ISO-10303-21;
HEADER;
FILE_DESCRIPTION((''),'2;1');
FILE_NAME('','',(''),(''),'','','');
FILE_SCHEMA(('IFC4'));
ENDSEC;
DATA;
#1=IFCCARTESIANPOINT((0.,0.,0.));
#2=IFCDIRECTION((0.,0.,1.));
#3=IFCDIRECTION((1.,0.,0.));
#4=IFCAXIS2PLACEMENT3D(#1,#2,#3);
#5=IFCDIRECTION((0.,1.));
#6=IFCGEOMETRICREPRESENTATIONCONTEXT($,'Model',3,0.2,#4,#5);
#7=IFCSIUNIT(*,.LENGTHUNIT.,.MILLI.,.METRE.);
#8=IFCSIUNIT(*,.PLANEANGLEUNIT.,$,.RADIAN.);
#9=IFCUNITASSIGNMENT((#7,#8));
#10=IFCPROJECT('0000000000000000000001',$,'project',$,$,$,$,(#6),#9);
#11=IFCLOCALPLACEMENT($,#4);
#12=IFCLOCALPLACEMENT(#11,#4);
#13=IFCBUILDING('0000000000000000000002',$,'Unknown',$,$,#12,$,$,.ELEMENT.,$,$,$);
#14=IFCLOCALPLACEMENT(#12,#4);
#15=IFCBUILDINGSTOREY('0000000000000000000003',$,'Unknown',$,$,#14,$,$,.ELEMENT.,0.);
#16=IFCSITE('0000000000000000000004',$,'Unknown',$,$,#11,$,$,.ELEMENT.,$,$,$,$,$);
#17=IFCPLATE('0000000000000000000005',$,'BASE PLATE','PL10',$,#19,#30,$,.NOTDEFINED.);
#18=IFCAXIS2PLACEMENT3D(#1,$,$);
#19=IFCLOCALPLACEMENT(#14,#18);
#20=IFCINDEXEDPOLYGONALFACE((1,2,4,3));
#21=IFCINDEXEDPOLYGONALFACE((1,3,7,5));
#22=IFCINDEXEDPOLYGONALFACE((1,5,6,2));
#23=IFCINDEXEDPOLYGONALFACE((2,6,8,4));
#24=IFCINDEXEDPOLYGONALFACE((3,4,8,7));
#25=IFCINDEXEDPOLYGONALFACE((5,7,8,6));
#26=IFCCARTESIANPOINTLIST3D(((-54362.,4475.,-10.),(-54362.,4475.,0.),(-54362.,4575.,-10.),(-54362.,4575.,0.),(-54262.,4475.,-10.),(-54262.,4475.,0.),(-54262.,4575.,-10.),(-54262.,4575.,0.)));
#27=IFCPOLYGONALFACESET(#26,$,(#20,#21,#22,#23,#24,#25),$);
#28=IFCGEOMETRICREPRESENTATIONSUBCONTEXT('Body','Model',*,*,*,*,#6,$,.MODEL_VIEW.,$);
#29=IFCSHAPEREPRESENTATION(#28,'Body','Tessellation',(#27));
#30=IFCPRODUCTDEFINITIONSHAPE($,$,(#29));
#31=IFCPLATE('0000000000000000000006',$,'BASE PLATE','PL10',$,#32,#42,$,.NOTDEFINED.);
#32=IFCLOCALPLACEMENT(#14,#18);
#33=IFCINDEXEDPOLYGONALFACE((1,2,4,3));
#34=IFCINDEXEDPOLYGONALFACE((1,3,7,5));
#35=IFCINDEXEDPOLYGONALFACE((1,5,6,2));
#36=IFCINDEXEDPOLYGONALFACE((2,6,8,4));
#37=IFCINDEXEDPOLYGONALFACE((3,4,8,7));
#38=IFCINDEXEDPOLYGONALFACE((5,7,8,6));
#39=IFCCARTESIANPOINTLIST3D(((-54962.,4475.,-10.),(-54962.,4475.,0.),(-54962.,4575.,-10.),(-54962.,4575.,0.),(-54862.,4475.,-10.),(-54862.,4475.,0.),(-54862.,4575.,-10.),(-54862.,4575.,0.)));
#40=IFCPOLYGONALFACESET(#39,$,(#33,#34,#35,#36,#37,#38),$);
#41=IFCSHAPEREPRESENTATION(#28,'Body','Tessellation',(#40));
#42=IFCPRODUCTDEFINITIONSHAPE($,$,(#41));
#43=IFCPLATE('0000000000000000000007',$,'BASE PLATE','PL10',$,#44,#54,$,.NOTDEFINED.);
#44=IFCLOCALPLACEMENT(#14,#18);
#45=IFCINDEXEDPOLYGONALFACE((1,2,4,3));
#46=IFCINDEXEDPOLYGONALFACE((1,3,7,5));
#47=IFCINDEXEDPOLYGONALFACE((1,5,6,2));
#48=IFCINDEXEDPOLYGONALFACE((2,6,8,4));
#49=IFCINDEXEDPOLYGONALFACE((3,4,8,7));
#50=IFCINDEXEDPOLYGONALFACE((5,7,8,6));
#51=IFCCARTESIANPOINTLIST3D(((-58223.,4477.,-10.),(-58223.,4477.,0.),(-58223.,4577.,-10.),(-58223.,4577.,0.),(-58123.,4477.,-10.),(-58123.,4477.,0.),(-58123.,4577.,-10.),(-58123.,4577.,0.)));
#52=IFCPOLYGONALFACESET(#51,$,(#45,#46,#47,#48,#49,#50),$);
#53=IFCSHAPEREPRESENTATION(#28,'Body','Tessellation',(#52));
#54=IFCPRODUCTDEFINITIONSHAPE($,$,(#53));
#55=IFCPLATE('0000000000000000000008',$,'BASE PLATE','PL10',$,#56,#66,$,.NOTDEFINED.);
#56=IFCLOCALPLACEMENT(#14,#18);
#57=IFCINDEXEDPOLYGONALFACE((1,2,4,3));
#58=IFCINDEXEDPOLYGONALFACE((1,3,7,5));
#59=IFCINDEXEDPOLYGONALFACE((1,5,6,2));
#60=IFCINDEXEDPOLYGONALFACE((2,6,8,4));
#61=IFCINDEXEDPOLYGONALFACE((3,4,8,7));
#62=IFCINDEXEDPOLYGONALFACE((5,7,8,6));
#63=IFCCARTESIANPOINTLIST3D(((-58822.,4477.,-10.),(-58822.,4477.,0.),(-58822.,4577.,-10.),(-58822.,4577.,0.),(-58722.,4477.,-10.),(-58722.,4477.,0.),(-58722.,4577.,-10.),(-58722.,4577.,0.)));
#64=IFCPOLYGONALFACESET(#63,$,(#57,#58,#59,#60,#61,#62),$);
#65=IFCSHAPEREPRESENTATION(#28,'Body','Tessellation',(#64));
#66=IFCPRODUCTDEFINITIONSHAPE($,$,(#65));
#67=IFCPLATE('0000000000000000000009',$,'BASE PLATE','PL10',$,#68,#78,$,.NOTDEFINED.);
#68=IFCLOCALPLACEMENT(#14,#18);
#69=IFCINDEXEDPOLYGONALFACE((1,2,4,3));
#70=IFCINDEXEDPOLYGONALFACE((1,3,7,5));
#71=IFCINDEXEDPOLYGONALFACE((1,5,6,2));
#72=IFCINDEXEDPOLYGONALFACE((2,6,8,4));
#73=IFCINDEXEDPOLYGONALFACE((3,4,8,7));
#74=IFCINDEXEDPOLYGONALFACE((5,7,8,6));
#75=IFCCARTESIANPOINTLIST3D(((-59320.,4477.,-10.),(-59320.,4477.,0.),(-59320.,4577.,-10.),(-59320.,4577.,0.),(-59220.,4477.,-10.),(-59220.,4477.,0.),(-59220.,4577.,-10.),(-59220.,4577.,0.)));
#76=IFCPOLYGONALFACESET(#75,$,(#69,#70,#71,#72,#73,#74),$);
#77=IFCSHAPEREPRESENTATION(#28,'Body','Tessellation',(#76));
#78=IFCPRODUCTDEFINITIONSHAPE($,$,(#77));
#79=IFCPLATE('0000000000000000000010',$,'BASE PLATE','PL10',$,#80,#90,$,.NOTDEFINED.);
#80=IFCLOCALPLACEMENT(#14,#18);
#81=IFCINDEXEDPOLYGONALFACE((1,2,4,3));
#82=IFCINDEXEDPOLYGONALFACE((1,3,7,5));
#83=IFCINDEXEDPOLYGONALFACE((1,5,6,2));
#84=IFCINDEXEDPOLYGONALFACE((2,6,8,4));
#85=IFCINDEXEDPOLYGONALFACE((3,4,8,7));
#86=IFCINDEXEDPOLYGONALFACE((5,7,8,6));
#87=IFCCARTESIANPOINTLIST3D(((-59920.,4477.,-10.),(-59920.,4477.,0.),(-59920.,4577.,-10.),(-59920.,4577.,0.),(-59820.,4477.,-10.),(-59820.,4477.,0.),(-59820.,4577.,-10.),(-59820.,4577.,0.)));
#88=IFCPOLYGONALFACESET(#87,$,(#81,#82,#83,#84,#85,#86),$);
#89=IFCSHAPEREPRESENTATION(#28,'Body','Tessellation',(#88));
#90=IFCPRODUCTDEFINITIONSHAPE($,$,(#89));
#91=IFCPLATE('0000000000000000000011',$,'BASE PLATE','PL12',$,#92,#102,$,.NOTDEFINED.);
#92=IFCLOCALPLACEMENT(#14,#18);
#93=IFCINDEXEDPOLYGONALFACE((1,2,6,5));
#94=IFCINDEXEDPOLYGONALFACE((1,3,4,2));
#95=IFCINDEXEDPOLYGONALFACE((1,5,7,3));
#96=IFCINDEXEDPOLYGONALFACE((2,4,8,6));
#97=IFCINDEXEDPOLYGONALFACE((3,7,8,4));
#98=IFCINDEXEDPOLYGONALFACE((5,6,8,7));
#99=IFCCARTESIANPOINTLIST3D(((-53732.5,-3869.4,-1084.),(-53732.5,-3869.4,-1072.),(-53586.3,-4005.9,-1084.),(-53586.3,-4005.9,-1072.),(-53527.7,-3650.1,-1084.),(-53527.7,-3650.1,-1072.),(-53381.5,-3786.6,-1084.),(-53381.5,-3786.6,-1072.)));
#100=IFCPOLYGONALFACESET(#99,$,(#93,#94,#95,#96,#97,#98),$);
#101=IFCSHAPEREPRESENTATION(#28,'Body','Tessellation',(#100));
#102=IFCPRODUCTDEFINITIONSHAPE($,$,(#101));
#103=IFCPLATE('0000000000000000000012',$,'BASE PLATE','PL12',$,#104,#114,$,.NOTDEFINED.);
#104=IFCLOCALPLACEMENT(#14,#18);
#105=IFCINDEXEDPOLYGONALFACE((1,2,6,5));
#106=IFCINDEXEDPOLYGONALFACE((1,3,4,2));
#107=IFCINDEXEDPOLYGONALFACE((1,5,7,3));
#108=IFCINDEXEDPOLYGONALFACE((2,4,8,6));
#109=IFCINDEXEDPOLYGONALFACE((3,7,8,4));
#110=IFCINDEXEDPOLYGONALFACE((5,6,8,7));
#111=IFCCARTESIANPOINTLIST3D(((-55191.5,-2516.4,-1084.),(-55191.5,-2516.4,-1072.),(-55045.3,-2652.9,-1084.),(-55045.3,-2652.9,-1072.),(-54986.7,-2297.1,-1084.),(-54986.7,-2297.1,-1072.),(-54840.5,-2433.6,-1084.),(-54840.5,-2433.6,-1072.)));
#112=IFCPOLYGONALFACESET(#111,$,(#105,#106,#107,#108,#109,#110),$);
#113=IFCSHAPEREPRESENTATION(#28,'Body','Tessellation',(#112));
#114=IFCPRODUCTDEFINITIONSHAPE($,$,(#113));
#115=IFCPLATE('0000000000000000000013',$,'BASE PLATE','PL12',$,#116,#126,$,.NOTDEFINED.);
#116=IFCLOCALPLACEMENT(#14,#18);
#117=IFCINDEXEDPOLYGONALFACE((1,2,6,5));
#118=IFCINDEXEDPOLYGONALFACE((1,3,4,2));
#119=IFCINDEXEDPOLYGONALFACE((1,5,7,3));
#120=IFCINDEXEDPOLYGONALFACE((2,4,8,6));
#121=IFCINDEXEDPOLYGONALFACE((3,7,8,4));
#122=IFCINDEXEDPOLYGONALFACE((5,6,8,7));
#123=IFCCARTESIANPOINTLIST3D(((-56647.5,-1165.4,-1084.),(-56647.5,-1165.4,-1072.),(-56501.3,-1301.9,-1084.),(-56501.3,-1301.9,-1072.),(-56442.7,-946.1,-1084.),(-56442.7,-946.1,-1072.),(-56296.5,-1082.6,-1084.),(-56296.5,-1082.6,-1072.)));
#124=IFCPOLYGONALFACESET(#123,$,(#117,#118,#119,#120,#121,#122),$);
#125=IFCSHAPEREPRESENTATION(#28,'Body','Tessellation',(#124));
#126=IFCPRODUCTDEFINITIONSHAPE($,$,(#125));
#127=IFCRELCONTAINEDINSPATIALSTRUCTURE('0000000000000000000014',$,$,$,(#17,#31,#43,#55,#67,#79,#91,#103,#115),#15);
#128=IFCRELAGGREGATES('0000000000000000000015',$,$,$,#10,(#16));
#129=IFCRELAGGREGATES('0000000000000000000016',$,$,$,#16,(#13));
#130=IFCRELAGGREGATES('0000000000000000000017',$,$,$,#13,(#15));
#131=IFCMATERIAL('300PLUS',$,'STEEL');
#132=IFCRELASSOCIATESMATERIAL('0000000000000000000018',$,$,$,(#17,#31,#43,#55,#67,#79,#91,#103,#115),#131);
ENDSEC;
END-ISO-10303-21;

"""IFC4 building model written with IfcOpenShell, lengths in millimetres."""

from ifc_helpers import new_model, si_unit, direction, frame, origin_with_axes, place, context, subcontext, project, spatial, line, indexed_curve, outline, extrude, material, element, save


model = new_model("IFC4")

# Units and contexts
model_context = context("Model", 3, precision=0.2, world=origin_with_axes(), true_north=direction((0.0, 1.0)))
body_context = subcontext(model_context, "Body", "Model", "MODEL_VIEW")
ifc_project = project(units=[si_unit("LENGTHUNIT", "METRE", prefix="MILLI"), si_unit("PLANEANGLEUNIT", "RADIAN")], contexts=[model_context])

# Site, building, storey
site_placement = place(None, origin_with_axes())
site = spatial("IfcSite", under=ifc_project, at=site_placement, Name="Unknown", CompositionType="ELEMENT")
building_placement = place(site_placement, origin_with_axes())
building = spatial("IfcBuilding", under=site, at=building_placement, Name="Unknown", CompositionType="ELEMENT")
storey_placement = place(building_placement, origin_with_axes())
storey = spatial("IfcBuildingStorey", under=building, at=storey_placement, Name="Unknown", CompositionType="ELEMENT", Elevation=0.0)

# Shared definitions
ifc_material_1 = material(Name="300PLUS", Category="STEEL")

# Plates
for number, where, z_axis, x_axis, name in (
    (1, (-54362.0, 4475.0, -5.0), (0.0, 0.0, 1.0), (1.0, 0.0, 0.0), "BASE PLATE"),
    (2, (-54962.0, 4475.0, -5.0), (0.0, 0.0, 1.0), (1.0, 0.0, 0.0), "BASE PLATE"),
    (3, (-58223.0, 4477.0, -5.0), (0.0, 0.0, 1.0), (1.0, 0.0, 0.0), "BASE PLATE"),
    (4, (-58822.0, 4477.0, -5.0), (0.0, 0.0, 1.0), (1.0, 0.0, 0.0), "BASE PLATE"),
    (5, (-59320.0, 4477.0, -5.0), (0.0, 0.0, 1.0), (1.0, 0.0, 0.0), "BASE PLATE"),
    (6, (-59920.0, 4477.0, -5.0), (0.0, 0.0, 1.0), (1.0, 0.0, 0.0), "BASE PLATE"),
):
    element("IfcPlate", number, at=place(storey_placement, frame(where, z_axis=z_axis, x_axis=x_axis)), inside=storey, material=ifc_material_1, Name=name, Description="PL10", PredefinedType="NOTDEFINED", context=body_context, shape_type="SolidModel", body=[
        extrude(outline(indexed_curve([(0.0, 0.0), (100.0, 0.0), (100.0, 100.0), (0.0, 100.0)], segments=[line(1, 2, 3, 4, 1)])), frame((0.0, 0.0, 5.0), z_axis=(0.0, 0.0, 1.0), x_axis=(1.0, 0.0, 0.0)), (0.0, 0.0, -1.0), 10.0),
    ])
for number, where, z_axis, x_axis, name in (
    (7, (-53586.3, -4005.9, -1078.0), (0.0, 0.0, 1.0), (0.682532, 0.730856, 0.0), "BASE PLATE"),
    (8, (-55045.3, -2652.9, -1078.0), (0.0, 0.0, 1.0), (0.682532, 0.730856, 0.0), "BASE PLATE"),
    (9, (-56501.3, -1301.9, -1078.0), (0.0, 0.0, 1.0), (0.682532, 0.730856, 0.0), "BASE PLATE"),
):
    element("IfcPlate", number, at=place(storey_placement, frame(where, z_axis=z_axis, x_axis=x_axis)), inside=storey, material=ifc_material_1, Name=name, Description="PL12", PredefinedType="NOTDEFINED", context=body_context, shape_type="SolidModel", body=[
        extrude(outline(indexed_curve([(0.0, 0.0), (300.1, 0.0), (300.0, 200.0), (0.0, 200.0)], segments=[line(1, 2, 3, 4, 1)])), frame((0.0, 0.0, 6.0), z_axis=(0.0, 0.0, 1.0), x_axis=(1.0, 0.0, 0.0)), (0.0, 0.0, -1.0), 12.0),
    ])

save(model, "model.ifc")
